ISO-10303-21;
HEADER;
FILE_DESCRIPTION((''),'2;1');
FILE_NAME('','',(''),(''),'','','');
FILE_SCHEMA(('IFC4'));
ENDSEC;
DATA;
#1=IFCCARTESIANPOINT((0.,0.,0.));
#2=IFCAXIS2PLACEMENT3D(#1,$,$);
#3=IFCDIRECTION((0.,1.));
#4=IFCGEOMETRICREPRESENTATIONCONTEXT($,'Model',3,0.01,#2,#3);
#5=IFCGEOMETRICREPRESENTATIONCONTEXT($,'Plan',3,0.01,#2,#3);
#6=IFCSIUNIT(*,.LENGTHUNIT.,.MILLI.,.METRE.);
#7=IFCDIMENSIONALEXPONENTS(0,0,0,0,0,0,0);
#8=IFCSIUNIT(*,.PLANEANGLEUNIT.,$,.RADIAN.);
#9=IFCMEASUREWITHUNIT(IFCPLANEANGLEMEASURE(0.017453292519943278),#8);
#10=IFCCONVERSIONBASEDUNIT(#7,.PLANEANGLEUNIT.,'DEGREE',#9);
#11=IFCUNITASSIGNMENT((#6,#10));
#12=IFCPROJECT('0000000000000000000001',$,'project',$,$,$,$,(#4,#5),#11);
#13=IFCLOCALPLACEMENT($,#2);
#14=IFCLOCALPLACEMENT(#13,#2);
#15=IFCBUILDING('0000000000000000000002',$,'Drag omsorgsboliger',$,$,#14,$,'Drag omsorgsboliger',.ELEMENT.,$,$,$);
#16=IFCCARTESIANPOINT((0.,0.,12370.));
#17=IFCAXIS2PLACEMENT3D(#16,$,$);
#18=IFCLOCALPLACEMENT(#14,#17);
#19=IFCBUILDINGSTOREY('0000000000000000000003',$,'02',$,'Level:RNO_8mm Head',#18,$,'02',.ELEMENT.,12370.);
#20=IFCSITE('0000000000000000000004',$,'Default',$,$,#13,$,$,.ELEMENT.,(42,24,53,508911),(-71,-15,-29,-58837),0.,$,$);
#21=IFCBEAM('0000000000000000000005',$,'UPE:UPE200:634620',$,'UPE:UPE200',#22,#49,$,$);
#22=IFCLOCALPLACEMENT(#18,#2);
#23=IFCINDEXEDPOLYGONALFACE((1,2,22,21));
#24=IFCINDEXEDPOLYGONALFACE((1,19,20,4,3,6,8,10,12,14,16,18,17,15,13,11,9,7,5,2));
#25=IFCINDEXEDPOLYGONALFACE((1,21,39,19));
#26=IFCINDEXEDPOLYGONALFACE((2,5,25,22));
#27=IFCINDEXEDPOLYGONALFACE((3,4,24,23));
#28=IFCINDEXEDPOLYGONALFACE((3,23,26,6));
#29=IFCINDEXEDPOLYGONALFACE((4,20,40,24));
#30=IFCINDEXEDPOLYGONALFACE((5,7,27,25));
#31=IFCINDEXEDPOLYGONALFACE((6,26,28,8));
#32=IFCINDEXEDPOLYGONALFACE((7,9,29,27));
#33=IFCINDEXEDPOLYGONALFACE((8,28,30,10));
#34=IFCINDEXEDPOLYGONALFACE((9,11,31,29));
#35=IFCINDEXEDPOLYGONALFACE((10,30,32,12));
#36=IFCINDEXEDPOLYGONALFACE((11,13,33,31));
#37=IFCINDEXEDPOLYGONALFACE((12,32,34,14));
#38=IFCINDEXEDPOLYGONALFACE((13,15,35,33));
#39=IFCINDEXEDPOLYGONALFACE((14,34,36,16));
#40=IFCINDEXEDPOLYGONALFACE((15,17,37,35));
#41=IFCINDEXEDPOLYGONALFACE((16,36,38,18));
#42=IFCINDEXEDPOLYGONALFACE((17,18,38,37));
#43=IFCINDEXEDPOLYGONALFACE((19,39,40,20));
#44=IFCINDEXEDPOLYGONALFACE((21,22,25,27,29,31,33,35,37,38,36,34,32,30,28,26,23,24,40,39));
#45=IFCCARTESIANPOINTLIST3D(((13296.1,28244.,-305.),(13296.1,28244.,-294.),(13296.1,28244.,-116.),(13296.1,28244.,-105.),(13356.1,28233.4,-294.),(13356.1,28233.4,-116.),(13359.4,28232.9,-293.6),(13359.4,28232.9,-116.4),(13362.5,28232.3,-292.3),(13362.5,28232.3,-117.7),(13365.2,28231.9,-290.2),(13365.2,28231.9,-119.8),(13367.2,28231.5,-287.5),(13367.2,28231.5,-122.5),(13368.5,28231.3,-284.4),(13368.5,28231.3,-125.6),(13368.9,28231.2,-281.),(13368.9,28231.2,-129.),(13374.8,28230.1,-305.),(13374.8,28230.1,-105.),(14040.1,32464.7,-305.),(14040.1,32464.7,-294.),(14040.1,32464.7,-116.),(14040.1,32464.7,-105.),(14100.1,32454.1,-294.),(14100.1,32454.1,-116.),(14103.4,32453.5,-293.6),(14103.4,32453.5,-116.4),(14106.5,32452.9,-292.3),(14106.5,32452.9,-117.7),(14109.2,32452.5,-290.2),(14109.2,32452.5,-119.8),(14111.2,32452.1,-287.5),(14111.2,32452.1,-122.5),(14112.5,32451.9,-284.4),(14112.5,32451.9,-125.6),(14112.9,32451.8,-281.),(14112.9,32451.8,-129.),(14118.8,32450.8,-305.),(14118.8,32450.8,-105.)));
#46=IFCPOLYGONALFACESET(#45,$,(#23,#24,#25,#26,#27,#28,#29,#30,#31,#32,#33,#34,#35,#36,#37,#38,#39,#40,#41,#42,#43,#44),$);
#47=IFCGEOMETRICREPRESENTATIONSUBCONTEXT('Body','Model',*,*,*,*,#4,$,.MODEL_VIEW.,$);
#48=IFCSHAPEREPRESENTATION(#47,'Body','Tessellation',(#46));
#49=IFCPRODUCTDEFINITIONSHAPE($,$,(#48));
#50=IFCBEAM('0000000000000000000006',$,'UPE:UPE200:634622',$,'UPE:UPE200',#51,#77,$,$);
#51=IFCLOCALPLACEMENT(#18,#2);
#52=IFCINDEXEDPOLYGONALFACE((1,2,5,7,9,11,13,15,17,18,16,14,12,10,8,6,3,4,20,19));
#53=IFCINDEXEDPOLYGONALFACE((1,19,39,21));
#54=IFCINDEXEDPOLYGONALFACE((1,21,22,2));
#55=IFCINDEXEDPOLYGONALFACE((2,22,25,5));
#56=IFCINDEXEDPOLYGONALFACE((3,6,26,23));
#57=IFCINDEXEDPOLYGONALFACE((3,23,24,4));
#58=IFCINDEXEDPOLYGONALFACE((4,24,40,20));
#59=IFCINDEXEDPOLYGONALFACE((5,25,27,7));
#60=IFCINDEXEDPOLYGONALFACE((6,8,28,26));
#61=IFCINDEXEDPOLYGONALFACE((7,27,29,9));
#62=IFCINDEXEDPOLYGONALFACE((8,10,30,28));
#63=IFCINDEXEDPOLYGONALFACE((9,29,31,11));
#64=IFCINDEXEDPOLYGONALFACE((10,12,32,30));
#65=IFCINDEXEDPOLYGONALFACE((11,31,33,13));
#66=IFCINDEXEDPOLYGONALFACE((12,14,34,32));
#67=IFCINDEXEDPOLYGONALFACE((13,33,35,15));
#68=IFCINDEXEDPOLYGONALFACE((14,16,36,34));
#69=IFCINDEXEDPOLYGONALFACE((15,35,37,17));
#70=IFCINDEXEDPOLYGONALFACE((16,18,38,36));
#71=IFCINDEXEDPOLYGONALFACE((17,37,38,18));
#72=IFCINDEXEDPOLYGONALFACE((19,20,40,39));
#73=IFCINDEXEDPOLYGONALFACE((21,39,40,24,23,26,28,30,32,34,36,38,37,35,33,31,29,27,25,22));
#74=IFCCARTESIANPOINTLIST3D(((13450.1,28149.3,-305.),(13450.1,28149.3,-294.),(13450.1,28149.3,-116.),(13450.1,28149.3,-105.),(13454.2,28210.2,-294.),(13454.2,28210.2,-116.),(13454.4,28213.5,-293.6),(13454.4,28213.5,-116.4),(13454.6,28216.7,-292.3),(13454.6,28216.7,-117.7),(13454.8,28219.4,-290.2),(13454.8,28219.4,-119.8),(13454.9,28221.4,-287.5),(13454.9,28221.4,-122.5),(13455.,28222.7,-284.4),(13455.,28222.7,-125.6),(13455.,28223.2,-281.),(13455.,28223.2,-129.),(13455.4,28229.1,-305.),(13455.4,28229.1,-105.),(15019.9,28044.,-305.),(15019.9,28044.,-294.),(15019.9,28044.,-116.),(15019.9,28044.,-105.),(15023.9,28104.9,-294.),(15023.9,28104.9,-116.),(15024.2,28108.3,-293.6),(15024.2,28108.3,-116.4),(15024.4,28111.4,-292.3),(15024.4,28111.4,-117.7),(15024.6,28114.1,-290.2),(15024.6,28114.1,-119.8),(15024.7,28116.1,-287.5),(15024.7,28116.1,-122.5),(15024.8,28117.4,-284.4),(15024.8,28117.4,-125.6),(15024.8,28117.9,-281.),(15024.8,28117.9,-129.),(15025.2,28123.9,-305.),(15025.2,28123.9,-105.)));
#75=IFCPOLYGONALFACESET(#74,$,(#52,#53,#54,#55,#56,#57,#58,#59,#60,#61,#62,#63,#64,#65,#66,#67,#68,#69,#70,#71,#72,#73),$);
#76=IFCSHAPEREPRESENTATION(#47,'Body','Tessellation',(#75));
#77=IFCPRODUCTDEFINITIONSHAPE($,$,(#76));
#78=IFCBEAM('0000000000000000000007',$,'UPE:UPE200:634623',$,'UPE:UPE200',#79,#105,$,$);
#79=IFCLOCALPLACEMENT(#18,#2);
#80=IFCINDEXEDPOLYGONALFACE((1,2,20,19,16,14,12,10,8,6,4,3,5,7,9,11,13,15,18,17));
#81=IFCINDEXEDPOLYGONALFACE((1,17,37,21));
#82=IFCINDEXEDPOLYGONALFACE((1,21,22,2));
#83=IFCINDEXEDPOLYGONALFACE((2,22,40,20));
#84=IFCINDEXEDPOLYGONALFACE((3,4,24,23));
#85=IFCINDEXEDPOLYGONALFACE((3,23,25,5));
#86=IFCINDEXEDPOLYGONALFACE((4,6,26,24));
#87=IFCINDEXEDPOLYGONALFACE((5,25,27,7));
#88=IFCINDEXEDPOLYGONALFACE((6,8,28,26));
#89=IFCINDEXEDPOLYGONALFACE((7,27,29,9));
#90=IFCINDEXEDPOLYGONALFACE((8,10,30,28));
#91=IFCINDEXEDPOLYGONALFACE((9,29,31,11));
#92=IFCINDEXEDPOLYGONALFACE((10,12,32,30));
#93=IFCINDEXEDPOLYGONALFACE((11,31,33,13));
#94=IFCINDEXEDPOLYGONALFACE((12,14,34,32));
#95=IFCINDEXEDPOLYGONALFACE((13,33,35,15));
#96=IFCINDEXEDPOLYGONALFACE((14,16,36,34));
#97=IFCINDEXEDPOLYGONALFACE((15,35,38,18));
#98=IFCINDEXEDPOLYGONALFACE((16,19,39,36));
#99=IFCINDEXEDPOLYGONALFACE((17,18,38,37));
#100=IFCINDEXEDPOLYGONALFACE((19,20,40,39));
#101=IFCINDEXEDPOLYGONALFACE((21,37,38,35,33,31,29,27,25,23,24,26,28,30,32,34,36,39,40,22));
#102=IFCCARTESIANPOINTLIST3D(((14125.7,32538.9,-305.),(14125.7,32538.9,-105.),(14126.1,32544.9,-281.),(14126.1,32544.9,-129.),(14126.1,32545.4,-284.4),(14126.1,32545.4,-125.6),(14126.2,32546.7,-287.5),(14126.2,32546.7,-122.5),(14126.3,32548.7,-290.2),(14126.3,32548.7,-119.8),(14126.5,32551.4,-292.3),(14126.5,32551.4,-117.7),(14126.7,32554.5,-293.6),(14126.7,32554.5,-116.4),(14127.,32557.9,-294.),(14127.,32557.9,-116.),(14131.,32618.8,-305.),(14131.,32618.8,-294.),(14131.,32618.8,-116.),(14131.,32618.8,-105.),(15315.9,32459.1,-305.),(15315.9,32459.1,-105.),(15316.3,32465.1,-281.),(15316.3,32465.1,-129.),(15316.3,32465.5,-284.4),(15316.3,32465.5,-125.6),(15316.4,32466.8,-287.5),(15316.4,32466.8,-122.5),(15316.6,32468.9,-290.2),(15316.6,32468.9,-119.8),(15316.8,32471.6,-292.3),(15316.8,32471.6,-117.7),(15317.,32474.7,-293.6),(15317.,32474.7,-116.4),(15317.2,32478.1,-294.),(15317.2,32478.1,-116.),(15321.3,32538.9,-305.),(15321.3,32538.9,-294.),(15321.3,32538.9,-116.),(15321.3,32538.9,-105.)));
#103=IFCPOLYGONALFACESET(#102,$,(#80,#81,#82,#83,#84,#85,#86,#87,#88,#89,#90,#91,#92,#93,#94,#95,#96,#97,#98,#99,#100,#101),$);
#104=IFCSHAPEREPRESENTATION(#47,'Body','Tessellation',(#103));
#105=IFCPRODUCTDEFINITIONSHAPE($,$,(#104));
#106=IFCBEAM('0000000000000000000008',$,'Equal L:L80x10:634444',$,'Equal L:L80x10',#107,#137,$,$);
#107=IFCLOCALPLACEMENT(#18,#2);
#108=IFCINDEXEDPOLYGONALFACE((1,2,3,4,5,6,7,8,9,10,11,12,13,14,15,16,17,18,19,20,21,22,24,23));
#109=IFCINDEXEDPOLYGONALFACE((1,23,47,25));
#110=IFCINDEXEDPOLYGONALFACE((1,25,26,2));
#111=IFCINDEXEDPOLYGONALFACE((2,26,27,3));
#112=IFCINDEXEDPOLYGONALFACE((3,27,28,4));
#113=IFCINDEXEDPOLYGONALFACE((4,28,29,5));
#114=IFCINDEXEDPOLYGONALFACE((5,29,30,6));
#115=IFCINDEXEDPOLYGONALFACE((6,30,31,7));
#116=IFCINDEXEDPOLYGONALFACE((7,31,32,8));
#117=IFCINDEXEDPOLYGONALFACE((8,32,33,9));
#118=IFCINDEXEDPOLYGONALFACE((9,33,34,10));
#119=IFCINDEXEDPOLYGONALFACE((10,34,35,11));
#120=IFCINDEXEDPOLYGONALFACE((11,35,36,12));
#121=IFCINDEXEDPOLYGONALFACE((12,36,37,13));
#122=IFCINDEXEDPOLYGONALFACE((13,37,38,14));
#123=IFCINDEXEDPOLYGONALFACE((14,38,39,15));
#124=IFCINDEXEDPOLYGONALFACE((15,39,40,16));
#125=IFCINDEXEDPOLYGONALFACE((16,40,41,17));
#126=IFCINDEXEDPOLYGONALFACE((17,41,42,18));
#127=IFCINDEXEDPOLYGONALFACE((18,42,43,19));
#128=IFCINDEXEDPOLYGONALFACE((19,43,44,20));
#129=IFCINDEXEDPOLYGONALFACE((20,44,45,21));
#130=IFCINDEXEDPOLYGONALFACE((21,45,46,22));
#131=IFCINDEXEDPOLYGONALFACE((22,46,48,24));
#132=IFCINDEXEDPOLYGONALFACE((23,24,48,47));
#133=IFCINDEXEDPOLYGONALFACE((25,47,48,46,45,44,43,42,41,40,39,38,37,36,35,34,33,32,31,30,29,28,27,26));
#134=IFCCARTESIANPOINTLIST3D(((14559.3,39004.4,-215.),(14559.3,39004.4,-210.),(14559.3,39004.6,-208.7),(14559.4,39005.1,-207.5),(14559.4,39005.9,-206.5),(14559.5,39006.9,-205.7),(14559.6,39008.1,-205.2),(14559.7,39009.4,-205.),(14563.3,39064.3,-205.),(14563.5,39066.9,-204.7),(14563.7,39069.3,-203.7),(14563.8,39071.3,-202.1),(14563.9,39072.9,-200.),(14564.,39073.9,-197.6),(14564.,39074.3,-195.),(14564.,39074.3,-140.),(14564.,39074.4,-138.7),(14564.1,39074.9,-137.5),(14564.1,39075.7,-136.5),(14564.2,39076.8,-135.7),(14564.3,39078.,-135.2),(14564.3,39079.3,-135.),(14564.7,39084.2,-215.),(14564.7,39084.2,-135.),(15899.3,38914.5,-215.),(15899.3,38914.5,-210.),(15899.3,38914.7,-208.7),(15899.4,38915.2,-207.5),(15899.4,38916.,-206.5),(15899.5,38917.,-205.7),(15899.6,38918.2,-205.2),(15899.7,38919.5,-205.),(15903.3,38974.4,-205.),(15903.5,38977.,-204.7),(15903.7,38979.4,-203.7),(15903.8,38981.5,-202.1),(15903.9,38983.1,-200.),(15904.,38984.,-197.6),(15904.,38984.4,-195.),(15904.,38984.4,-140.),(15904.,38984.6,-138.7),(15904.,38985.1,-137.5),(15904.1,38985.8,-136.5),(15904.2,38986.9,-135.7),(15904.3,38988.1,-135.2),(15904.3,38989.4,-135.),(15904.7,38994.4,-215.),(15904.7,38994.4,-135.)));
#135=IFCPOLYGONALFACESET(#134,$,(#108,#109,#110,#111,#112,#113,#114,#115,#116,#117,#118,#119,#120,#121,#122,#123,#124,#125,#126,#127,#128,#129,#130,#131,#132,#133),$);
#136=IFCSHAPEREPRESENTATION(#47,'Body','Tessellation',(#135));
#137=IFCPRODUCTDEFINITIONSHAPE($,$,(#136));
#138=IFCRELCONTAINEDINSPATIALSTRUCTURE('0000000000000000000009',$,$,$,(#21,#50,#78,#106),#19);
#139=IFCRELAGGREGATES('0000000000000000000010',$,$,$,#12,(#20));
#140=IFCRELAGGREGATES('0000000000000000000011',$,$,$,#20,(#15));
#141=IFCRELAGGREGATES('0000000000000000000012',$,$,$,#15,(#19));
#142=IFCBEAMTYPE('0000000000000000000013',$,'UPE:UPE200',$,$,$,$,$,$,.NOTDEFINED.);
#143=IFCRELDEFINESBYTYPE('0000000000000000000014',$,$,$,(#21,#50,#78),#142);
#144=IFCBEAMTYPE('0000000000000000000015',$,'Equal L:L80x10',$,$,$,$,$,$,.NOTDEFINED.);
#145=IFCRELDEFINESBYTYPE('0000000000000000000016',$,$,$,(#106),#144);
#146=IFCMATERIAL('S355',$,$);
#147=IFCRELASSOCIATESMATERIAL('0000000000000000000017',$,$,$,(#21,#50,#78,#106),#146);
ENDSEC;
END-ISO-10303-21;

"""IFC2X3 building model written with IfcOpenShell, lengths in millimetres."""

from ifc_helpers import new_model, entity, si_unit, converted_unit, direction, frame, frame_2d, origin, place, context, subcontext, project, spatial, polyline, circle_curve, parameter, trimmed, segment, composite_curve, outline, extrude, material, type_object, element, save


model = new_model("IFC2X3")

# Units and contexts
model_context = context("Model", 3, precision=0.01, world=origin(), true_north=direction((0.0, 1.0)))
plan_context = context("Plan", 3, precision=0.01, world=origin(), true_north=direction((0.0, 1.0)))
body_context = subcontext(model_context, "Body", "Model", "MODEL_VIEW")
ifc_project = project(units=[si_unit("LENGTHUNIT", "METRE", prefix="MILLI"), converted_unit("PLANEANGLEUNIT", "DEGREE", entity("IfcPlaneAngleMeasure", 0.017453292519943278), si_unit("PLANEANGLEUNIT", "RADIAN"), dimensions=[0, 0, 0, 0, 0, 0, 0])], contexts=[model_context, plan_context])

# Site, building, storey
site_placement = place(None, origin())
site = spatial("IfcSite", under=ifc_project, at=site_placement, Name="Default", CompositionType="ELEMENT", RefLatitude=(42, 24, 53, 508911), RefLongitude=(-71, -15, -29, -58837), RefElevation=0.0)
building_placement = place(site_placement, origin())
building = spatial("IfcBuilding", under=site, at=building_placement, Name="Drag omsorgsboliger", LongName="Drag omsorgsboliger", CompositionType="ELEMENT")
storey_placement = place(building_placement, frame((0.0, 0.0, 12370.0)))
storey = spatial("IfcBuildingStorey", under=building, at=storey_placement, Name="02", ObjectType="Level:RNO_8mm Head", LongName="02", CompositionType="ELEMENT", Elevation=12370.0)

# Beams
ifc_material = material(Name="S355")
beam_type_1 = type_object("IfcBeamType", Name="UPE:UPE200", PredefinedType="NOTDEFINED")
beam_1_placement = place(storey_placement, frame((14108.5, 32539.5, -105.0), z_axis=(0.0, 0.0, 1.0), x_axis=(-0.173601, -0.984816, 0.0)))
element("IfcBeam", 1, at=beam_1_placement, inside=storey, type_object=beam_type_1, material=ifc_material, Name="UPE:UPE200:634620", ObjectType="UPE:UPE200", context=body_context, shape_type="SweptSolid", body=[
    extrude(outline(composite_curve([segment(polyline([(-100.0, -43.0), (-89.0, -43.0)]), True, "CONTINUOUS"), segment(polyline([(-89.0, -43.0), (-89.0, 18.0)]), True, "CONTINUOUS"), segment(trimmed(circle_curve(frame_2d((-76.0, 18.0), x_axis=(-1.0, 0.0)), 13.0), [parameter(270.0)], [parameter(0.0)], True, "PARAMETER"), False, "CONTINUOUS"), segment(polyline([(-76.0, 31.0), (76.0, 31.0)]), True, "CONTINUOUS"), segment(trimmed(circle_curve(frame_2d((76.0, 18.0), x_axis=(0.0, 1.0)), 13.0), [parameter(270.0)], [parameter(0.0)], True, "PARAMETER"), False, "CONTINUOUS"), segment(polyline([(89.0, 18.0), (89.0, -43.0)]), True, "CONTINUOUS"), segment(polyline([(89.0, -43.0), (100.0, -43.0)]), True, "CONTINUOUS"), segment(polyline([(100.0, -43.0), (100.0, 37.0)]), True, "CONTINUOUS"), segment(polyline([(100.0, 37.0), (-100.0, 37.0)]), True, "CONTINUOUS"), segment(polyline([(-100.0, 37.0), (-100.0, -43.0)]), True, "CONTINUOUS")], self_intersect=False)), frame((85.6, -11.4, -100.0), z_axis=(1.0, 0.0, 0.0), x_axis=(0.0, 0.0, -1.0)), (0.0, 0.0, 1.0), 4285.7),
])
beam_2_placement = place(storey_placement, frame((15023.5, 28098.3, -105.0), z_axis=(0.0, 0.0, 1.0), x_axis=(-0.997758, 0.066923, 0.0)))
element("IfcBeam", 2, at=beam_2_placement, inside=storey, type_object=beam_type_1, material=ifc_material, Name="UPE:UPE200:634622", ObjectType="UPE:UPE200", context=body_context, shape_type="SweptSolid", body=[
    extrude(outline(composite_curve([segment(polyline([(-100.0, -37.0), (100.0, -37.0)]), True, "CONTINUOUS"), segment(polyline([(100.0, -37.0), (100.0, 43.0)]), True, "CONTINUOUS"), segment(polyline([(100.0, 43.0), (89.0, 43.0)]), True, "CONTINUOUS"), segment(polyline([(89.0, 43.0), (89.0, -18.0)]), True, "CONTINUOUS"), segment(trimmed(circle_curve(frame_2d((76.0, -18.0), x_axis=(1.0, 0.0)), 13.0), [parameter(270.0)], [parameter(0.0)], True, "PARAMETER"), False, "CONTINUOUS"), segment(polyline([(76.0, -31.0), (-76.0, -31.0)]), True, "CONTINUOUS"), segment(trimmed(circle_curve(frame_2d((-76.0, -18.0), x_axis=(0.0, -1.0)), 13.0), [parameter(270.0)], [parameter(0.0)], True, "PARAMETER"), False, "CONTINUOUS"), segment(polyline([(-89.0, -18.0), (-89.0, 43.0)]), True, "CONTINUOUS"), segment(polyline([(-89.0, 43.0), (-100.0, 43.0)]), True, "CONTINUOUS"), segment(polyline([(-100.0, 43.0), (-100.0, -37.0)]), True, "CONTINUOUS")], self_intersect=False)), frame((0.0, 11.4, -100.0), z_axis=(1.0, 0.0, 0.0), x_axis=(0.0, 0.0, -1.0)), (0.0, 0.0, 1.0), 1573.3),
])
beam_3_placement = place(storey_placement, frame((15398.0, 32479.3, -105.0), z_axis=(0.0, 0.0, 1.0), x_axis=(-0.997758, 0.066923, 0.0)))
element("IfcBeam", 3, at=beam_3_placement, inside=storey, type_object=beam_type_1, material=ifc_material, Name="UPE:UPE200:634623", ObjectType="UPE:UPE200", context=body_context, shape_type="SweptSolid", body=[
    extrude(outline(composite_curve([segment(polyline([(-100.0, -43.0), (-89.0, -43.0)]), True, "CONTINUOUS"), segment(polyline([(-89.0, -43.0), (-89.0, 18.0)]), True, "CONTINUOUS"), segment(trimmed(circle_curve(frame_2d((-76.0, 18.0), x_axis=(-1.0, 0.0)), 13.0), [parameter(270.0)], [parameter(0.0)], True, "PARAMETER"), False, "CONTINUOUS"), segment(polyline([(-76.0, 31.0), (76.0, 31.0)]), True, "CONTINUOUS"), segment(trimmed(circle_curve(frame_2d((76.0, 18.0), x_axis=(0.0, 1.0)), 13.0), [parameter(270.0)], [parameter(0.0)], True, "PARAMETER"), False, "CONTINUOUS"), segment(polyline([(89.0, 18.0), (89.0, -43.0)]), True, "CONTINUOUS"), segment(polyline([(89.0, -43.0), (100.0, -43.0)]), True, "CONTINUOUS"), segment(polyline([(100.0, -43.0), (100.0, 37.0)]), True, "CONTINUOUS"), segment(polyline([(100.0, 37.0), (-100.0, 37.0)]), True, "CONTINUOUS"), segment(polyline([(-100.0, 37.0), (-100.0, -43.0)]), True, "CONTINUOUS")], self_intersect=False)), frame((80.5, -11.4, -100.0), z_axis=(1.0, 0.0, 0.0), x_axis=(0.0, 0.0, -1.0)), (0.0, 0.0, 1.0), 1192.9),
])
beam_type_2 = type_object("IfcBeamType", Name="Equal L:L80x10", PredefinedType="NOTDEFINED")
beam_4_placement = place(storey_placement, frame((15833.3, 38975.7, -135.0), z_axis=(0.0, 0.0, 1.0), x_axis=(-0.997758, 0.066923, 0.0)))
element("IfcBeam", 4, at=beam_4_placement, inside=storey, type_object=beam_type_2, material=ifc_material, Name="Equal L:L80x10:634444", ObjectType="Equal L:L80x10", context=body_context, shape_type="SweptSolid", body=[
    extrude(outline(composite_curve([segment(polyline([(-48.9, -31.1), (31.1, -31.1)]), True, "CONTINUOUS"), segment(polyline([(31.1, -31.1), (31.1, 48.9)]), True, "CONTINUOUS"), segment(polyline([(31.1, 48.9), (26.1, 48.9)]), True, "CONTINUOUS"), segment(trimmed(circle_curve(frame_2d((26.1, 43.9), x_axis=(0.0, 1.0)), 5.0), [parameter(0.0)], [parameter(90.0)], True, "PARAMETER"), True, "CONTINUOUS"), segment(polyline([(21.1, 43.9), (21.1, -11.1)]), True, "CONTINUOUS"), segment(trimmed(circle_curve(frame_2d((11.1, -11.1), x_axis=(1.0, 0.0)), 10.0), [parameter(270.0)], [parameter(0.0)], True, "PARAMETER"), False, "CONTINUOUS"), segment(polyline([(11.1, -21.1), (-43.9, -21.1)]), True, "CONTINUOUS"), segment(trimmed(circle_curve(frame_2d((-43.9, -26.1), x_axis=(0.0, 1.0)), 5.0), [parameter(0.0)], [parameter(90.0)], True, "PARAMETER"), True, "CONTINUOUS"), segment(polyline([(-48.9, -26.1), (-48.9, -31.1)]), True, "CONTINUOUS")], self_intersect=False)), frame((-70.0, 7.7, -48.9), z_axis=(1.0, 0.0, 0.0), x_axis=(0.0, 0.0, -1.0)), (0.0, 0.0, 1.0), 1343.0),
])

save(model, "model.ifc")
